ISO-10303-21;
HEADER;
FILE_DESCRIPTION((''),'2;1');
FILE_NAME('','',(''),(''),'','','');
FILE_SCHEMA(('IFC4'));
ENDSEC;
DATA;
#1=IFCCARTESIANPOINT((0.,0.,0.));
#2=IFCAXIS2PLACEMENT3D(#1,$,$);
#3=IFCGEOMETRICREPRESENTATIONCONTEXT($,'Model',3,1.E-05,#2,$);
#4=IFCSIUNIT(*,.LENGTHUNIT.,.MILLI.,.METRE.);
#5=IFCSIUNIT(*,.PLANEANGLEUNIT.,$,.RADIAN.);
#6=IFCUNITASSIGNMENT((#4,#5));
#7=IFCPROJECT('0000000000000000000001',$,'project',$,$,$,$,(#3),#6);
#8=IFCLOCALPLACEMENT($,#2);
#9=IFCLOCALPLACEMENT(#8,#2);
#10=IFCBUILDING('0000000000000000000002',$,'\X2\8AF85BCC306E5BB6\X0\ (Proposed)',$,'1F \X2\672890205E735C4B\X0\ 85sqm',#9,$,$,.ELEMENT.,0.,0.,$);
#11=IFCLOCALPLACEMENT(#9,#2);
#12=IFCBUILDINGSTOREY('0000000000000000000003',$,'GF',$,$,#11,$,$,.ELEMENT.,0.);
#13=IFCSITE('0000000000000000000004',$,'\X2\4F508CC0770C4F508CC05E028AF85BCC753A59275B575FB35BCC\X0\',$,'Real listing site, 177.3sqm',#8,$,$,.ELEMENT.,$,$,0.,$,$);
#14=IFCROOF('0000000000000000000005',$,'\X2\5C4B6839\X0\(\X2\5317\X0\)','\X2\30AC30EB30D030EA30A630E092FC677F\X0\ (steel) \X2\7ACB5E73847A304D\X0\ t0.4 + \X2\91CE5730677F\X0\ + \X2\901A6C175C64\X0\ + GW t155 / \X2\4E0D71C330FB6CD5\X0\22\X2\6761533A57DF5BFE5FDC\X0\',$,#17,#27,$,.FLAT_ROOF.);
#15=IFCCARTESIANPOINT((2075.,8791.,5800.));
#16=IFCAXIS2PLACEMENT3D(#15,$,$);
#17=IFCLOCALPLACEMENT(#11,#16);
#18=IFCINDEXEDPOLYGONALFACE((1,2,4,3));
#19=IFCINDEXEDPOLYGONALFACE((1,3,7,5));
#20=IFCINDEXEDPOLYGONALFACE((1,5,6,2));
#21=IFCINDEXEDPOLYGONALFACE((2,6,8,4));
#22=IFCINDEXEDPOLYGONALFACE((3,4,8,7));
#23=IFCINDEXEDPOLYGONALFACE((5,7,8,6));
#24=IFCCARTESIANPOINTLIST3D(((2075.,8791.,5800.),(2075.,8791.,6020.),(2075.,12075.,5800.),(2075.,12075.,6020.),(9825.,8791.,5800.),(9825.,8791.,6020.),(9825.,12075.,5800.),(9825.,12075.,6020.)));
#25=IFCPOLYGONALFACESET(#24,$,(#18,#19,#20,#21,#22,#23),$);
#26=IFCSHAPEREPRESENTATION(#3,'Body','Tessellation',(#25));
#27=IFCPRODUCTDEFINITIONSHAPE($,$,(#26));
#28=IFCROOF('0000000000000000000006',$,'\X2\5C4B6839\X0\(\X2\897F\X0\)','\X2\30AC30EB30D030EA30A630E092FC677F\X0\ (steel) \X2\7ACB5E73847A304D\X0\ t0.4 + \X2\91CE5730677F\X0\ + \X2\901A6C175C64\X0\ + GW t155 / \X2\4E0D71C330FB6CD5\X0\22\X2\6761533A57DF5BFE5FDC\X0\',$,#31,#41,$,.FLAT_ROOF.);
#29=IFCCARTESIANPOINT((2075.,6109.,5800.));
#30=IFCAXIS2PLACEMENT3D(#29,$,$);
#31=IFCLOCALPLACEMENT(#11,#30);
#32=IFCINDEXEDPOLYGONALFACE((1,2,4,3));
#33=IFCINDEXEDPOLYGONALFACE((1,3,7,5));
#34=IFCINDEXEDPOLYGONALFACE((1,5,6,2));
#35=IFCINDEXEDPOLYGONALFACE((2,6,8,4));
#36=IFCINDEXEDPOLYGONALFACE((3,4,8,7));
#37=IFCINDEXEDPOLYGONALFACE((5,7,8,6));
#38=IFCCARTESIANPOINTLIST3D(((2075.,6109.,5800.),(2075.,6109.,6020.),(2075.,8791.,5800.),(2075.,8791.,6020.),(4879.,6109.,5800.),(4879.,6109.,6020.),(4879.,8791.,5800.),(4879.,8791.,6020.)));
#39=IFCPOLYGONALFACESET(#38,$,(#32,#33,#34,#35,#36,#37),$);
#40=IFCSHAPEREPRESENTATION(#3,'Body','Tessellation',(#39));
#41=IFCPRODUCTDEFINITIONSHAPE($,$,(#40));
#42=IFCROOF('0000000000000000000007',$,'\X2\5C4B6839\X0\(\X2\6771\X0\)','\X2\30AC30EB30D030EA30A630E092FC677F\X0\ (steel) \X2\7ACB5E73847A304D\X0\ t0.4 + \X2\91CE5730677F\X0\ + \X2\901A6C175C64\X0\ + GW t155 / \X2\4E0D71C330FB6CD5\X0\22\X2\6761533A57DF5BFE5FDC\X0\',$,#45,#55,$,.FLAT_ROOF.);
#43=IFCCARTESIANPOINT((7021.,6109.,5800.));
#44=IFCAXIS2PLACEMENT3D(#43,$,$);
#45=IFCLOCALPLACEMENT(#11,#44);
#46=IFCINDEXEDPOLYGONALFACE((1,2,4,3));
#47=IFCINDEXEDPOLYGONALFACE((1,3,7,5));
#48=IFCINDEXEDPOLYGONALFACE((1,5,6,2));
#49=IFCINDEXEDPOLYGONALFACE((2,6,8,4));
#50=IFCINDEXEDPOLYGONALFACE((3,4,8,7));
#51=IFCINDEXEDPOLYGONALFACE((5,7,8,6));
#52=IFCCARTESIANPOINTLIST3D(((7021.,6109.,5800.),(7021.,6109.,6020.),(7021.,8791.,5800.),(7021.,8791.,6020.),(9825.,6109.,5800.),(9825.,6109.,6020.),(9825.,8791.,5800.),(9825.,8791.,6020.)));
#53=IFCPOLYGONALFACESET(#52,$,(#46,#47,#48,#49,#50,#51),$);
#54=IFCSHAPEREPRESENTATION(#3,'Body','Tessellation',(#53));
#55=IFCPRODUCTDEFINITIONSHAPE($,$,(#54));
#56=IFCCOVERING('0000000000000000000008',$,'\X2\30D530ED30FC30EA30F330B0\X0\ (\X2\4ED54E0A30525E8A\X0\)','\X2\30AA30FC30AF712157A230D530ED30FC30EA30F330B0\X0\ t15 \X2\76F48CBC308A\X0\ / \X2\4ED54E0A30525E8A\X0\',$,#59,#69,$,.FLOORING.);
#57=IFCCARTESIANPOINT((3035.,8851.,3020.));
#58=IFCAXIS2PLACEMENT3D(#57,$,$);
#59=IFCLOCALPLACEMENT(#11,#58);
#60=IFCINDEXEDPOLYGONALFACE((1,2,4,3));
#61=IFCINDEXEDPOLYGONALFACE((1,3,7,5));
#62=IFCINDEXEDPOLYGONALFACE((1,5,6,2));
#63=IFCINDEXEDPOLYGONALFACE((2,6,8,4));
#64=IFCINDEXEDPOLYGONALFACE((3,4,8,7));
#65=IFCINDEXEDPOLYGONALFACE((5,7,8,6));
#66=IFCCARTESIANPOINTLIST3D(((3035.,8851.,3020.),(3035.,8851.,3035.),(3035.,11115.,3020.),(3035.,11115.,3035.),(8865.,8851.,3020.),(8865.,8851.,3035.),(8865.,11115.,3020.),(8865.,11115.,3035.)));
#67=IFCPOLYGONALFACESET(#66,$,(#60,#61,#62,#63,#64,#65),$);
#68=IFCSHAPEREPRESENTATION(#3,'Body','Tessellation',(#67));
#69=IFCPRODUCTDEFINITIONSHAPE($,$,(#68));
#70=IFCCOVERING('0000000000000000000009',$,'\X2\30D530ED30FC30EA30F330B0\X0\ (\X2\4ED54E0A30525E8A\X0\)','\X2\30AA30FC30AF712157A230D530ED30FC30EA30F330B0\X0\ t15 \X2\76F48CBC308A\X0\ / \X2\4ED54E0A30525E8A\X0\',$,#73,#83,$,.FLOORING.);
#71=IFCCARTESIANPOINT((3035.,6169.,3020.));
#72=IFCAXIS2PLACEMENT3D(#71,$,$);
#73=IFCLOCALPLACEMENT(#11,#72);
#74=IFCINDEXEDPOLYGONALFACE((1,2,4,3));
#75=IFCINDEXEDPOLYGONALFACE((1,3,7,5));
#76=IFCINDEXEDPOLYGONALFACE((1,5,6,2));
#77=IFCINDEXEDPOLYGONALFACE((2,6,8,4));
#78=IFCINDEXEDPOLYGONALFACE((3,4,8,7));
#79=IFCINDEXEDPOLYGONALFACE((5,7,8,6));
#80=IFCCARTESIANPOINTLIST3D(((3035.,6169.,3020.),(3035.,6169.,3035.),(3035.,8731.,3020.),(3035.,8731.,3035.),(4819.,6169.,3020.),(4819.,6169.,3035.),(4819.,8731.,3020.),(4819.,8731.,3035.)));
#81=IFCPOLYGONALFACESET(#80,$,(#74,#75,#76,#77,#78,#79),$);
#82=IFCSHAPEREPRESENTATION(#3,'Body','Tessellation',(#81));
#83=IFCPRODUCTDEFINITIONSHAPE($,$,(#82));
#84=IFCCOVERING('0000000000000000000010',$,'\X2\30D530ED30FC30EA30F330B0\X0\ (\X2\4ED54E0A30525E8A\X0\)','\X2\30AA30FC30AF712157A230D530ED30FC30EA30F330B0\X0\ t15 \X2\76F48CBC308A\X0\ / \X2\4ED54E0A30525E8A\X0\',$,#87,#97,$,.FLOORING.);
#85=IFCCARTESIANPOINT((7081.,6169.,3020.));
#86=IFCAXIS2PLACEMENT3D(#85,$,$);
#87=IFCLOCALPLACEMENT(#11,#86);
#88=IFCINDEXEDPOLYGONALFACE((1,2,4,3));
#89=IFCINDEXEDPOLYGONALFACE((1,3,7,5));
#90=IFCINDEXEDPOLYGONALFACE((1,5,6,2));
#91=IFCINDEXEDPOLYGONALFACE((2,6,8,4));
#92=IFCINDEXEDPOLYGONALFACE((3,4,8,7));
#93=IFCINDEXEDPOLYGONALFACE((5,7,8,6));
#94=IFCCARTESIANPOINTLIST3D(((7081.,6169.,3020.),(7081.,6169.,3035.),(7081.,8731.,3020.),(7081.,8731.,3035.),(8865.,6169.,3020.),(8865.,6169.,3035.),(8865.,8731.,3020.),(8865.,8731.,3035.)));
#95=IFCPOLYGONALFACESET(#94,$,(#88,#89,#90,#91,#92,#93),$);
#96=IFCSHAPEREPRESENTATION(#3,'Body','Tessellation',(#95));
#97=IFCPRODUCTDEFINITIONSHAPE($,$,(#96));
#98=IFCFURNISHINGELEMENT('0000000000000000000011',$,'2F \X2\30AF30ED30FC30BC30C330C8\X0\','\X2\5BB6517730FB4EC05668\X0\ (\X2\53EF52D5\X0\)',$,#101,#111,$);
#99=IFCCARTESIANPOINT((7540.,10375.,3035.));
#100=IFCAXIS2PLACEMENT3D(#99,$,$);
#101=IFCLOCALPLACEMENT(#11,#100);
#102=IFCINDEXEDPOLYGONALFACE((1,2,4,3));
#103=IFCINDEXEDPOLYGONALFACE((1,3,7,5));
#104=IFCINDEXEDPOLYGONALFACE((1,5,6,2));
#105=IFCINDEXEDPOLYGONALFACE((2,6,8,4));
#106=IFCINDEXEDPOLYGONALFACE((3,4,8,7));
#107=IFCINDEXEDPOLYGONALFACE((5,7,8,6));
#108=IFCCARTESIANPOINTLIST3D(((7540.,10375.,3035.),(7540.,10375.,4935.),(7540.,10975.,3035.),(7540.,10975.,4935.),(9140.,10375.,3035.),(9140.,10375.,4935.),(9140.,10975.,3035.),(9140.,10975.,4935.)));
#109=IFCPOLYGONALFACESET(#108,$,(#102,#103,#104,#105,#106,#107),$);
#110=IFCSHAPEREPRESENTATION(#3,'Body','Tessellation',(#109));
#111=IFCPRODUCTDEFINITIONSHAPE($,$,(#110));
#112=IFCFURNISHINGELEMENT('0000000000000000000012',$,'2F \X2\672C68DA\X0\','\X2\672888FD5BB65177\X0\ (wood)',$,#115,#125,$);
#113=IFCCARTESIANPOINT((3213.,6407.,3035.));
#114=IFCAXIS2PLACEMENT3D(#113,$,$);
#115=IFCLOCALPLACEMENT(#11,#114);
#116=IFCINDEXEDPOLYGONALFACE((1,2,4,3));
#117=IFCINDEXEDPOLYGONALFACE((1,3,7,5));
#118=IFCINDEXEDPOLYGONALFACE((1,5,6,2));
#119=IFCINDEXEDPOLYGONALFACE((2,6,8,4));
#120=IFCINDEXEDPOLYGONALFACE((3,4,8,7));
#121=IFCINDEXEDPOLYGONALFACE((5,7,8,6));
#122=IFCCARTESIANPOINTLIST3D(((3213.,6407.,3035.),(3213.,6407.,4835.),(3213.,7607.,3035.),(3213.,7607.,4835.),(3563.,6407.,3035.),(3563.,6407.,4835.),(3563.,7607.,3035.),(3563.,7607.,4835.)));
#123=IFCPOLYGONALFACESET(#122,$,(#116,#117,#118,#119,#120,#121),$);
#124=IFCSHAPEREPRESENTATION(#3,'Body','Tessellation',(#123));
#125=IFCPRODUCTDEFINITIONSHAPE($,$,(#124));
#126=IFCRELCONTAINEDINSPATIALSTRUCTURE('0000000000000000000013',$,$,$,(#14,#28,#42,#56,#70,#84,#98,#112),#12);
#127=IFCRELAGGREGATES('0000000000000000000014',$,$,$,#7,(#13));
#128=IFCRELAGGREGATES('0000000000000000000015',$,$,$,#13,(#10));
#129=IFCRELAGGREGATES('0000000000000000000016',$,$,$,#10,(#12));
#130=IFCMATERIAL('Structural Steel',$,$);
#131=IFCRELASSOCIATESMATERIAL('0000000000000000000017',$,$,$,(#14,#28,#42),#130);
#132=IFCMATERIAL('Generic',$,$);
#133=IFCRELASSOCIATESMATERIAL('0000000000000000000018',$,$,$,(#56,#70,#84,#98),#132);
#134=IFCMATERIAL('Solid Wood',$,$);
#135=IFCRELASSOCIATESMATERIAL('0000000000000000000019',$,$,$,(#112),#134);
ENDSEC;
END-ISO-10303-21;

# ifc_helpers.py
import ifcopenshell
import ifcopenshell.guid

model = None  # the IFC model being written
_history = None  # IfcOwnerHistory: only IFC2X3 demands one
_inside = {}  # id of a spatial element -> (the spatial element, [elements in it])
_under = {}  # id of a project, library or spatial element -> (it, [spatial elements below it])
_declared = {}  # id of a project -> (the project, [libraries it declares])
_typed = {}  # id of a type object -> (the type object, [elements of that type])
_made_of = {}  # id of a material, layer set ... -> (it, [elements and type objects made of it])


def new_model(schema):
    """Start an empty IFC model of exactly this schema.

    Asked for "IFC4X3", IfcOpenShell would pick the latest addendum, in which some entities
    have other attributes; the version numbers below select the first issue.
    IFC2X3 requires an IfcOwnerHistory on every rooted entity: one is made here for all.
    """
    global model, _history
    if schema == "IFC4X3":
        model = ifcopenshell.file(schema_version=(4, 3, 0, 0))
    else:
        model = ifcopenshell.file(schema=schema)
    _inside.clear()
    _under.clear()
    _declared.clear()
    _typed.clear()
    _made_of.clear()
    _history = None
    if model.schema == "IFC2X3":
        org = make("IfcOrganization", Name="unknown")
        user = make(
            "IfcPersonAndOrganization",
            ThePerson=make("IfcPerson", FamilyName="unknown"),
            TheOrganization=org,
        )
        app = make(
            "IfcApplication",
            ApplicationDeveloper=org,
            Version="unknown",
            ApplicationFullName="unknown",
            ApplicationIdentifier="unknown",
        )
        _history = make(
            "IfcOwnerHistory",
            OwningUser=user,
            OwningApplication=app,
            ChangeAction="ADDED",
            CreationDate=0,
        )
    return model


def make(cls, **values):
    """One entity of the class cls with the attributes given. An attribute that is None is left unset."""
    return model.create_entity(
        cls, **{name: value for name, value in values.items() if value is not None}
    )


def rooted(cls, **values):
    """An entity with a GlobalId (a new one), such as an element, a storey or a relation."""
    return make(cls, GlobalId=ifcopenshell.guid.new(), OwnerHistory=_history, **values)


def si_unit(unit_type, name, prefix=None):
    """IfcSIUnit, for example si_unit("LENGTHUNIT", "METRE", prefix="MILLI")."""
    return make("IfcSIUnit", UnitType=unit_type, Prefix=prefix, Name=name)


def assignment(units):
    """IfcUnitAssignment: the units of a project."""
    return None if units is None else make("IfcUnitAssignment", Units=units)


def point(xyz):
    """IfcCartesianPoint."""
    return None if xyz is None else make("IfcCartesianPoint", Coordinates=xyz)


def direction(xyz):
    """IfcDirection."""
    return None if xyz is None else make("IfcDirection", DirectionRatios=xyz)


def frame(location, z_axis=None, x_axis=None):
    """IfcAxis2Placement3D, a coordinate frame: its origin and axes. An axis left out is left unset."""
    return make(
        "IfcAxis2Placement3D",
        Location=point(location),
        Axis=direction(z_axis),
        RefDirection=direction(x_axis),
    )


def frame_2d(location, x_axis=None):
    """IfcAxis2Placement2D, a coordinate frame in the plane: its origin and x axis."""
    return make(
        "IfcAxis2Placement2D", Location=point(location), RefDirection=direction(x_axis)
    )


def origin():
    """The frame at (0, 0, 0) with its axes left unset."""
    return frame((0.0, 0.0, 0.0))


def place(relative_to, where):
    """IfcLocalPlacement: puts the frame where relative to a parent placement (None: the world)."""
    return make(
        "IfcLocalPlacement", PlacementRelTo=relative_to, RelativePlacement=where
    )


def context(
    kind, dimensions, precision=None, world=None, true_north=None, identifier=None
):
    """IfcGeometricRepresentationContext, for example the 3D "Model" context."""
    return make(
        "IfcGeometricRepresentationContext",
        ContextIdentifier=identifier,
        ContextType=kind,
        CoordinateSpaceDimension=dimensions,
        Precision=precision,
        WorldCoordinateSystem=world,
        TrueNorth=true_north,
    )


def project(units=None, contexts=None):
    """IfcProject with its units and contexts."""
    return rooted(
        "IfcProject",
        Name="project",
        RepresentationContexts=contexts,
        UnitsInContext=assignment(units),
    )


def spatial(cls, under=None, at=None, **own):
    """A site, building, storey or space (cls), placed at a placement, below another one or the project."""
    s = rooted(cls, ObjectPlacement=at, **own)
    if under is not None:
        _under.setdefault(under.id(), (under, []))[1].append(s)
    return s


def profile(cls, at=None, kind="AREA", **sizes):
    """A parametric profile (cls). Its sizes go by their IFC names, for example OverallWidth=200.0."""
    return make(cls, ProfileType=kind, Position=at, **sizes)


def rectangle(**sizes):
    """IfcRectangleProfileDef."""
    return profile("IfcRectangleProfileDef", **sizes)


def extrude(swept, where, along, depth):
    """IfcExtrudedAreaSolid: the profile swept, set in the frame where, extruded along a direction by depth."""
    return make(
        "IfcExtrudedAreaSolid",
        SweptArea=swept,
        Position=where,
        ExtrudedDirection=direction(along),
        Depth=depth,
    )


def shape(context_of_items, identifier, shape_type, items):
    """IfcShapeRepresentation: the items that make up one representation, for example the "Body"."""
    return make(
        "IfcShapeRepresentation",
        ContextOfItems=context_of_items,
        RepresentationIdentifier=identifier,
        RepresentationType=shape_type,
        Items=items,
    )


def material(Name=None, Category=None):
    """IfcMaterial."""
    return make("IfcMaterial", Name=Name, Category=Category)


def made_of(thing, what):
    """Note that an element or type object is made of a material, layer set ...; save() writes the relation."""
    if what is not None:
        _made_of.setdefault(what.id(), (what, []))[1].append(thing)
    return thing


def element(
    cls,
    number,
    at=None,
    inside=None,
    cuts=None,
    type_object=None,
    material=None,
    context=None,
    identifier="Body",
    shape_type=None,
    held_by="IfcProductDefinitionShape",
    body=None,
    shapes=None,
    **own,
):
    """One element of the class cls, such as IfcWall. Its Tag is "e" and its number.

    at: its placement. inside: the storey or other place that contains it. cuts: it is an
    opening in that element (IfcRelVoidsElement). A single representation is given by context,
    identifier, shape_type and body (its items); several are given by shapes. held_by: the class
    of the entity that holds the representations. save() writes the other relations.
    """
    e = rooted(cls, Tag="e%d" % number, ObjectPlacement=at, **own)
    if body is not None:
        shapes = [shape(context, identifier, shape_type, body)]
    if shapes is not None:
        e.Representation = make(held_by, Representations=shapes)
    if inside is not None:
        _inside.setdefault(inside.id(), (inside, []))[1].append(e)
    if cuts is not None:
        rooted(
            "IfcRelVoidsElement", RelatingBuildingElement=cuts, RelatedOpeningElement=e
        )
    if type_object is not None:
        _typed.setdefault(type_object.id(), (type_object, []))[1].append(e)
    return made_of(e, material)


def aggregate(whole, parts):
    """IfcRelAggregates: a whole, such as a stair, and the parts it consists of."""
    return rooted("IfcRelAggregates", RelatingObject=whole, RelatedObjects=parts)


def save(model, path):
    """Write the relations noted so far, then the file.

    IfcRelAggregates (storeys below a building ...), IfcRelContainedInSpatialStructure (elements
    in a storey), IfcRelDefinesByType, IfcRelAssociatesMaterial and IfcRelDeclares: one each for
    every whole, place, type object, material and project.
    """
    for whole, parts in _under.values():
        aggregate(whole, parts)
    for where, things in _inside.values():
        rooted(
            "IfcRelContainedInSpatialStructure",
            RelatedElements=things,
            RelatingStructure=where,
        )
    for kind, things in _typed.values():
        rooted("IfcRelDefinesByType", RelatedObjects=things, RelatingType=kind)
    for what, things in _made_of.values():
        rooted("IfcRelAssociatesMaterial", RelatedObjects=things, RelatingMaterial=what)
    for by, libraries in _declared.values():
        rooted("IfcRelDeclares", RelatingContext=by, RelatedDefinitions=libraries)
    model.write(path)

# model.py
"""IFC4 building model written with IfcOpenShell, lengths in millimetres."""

from ifc_helpers import new_model, si_unit, frame, frame_2d, origin, place, context, project, spatial, rectangle, extrude, material, element, save


model = new_model("IFC4")

# Units and contexts
model_context = context("Model", 3, precision=1e-05, world=origin())
ifc_project = project(units=[si_unit("LENGTHUNIT", "METRE", prefix="MILLI"), si_unit("PLANEANGLEUNIT", "RADIAN")], contexts=[model_context])

# Site, building, storey
site_placement = place(None, origin())
site = spatial("IfcSite", under=ifc_project, at=site_placement, Name="佐賀県佐賀市諸富町大字徳富", ObjectType="Real listing site, 177.3sqm", CompositionType="ELEMENT", RefElevation=0.0)
building_placement = place(site_placement, origin())
building = spatial("IfcBuilding", under=site, at=building_placement, Name="諸富の家 (Proposed)", ObjectType="1F 木造平屋 85sqm", CompositionType="ELEMENT", ElevationOfRefHeight=0.0, ElevationOfTerrain=0.0)
storey_placement = place(building_placement, origin())
storey = spatial("IfcBuildingStorey", under=building, at=storey_placement, Name="GF", CompositionType="ELEMENT", Elevation=0.0)

# Shared definitions
ifc_material_1 = material(Name="Solid Wood")

# Shared definitions
ifc_material_2 = material(Name="Generic")

# Roofs
ifc_material_3 = material(Name="Structural Steel")
for number, where, name in (
    (1, (2075.0, 8791.0, 5800.0), "屋根(北)"),
):
    element("IfcRoof", number, at=place(storey_placement, frame(where)), inside=storey, material=ifc_material_3, Name=name, Description="ガルバリウム鋼板 (steel) 立平葺き t0.4 + 野地板 + 通気層 + GW t155 / 不燃・法22条区域対応", PredefinedType="FLAT_ROOF", context=model_context, shape_type="SweptSolid", body=[
        extrude(rectangle(XDim=7750.0, YDim=3284.0, at=frame_2d((3875.0, 1642.0))), frame((2075.0, 8791.0, 5800.0)), (0.0, 0.0, 1.0), 220.0),
    ])
roof_1_placement = place(storey_placement, frame((2075.0, 6109.0, 5800.0)))
element("IfcRoof", 2, at=roof_1_placement, inside=storey, material=ifc_material_3, Name="屋根(西)", Description="ガルバリウム鋼板 (steel) 立平葺き t0.4 + 野地板 + 通気層 + GW t155 / 不燃・法22条区域対応", PredefinedType="FLAT_ROOF", context=model_context, shape_type="SweptSolid", body=[
    extrude(rectangle(XDim=2804.0, YDim=2682.0, at=frame_2d((1402.0, 1341.0))), frame((2075.0, 6109.0, 5800.0)), (0.0, 0.0, 1.0), 220.0),
])
roof_2_placement = place(storey_placement, frame((7021.0, 6109.0, 5800.0)))
element("IfcRoof", 3, at=roof_2_placement, inside=storey, material=ifc_material_3, Name="屋根(東)", Description="ガルバリウム鋼板 (steel) 立平葺き t0.4 + 野地板 + 通気層 + GW t155 / 不燃・法22条区域対応", PredefinedType="FLAT_ROOF", context=model_context, shape_type="SweptSolid", body=[
    extrude(rectangle(XDim=2804.0, YDim=2682.0, at=frame_2d((1402.0, 1341.0))), frame((7021.0, 6109.0, 5800.0)), (0.0, 0.0, 1.0), 220.0),
])

# Coverings
covering_1_placement = place(storey_placement, frame((3035.0, 8851.0, 3020.0)))
element("IfcCovering", 4, at=covering_1_placement, inside=storey, material=ifc_material_2, Name="フローリング (仕上げ床)", Description="オーク無垢フローリング t15 直貼り / 仕上げ床", PredefinedType="FLOORING", context=model_context, shape_type="SweptSolid", body=[
    extrude(rectangle(XDim=5830.0, YDim=2264.0, at=frame_2d((2915.0, 1132.0))), frame((3035.0, 8851.0, 3020.0)), (0.0, 0.0, 1.0), 15.0),
])
covering_2_placement = place(storey_placement, frame((3035.0, 6169.0, 3020.0)))
element("IfcCovering", 5, at=covering_2_placement, inside=storey, material=ifc_material_2, Name="フローリング (仕上げ床)", Description="オーク無垢フローリング t15 直貼り / 仕上げ床", PredefinedType="FLOORING", context=model_context, shape_type="SweptSolid", body=[
    extrude(rectangle(XDim=1784.0, YDim=2562.0, at=frame_2d((892.0, 1281.0))), frame((3035.0, 6169.0, 3020.0)), (0.0, 0.0, 1.0), 15.0),
])
covering_3_placement = place(storey_placement, frame((7081.0, 6169.0, 3020.0)))
element("IfcCovering", 6, at=covering_3_placement, inside=storey, material=ifc_material_2, Name="フローリング (仕上げ床)", Description="オーク無垢フローリング t15 直貼り / 仕上げ床", PredefinedType="FLOORING", context=model_context, shape_type="SweptSolid", body=[
    extrude(rectangle(XDim=1784.0, YDim=2562.0, at=frame_2d((892.0, 1281.0))), frame((7081.0, 6169.0, 3020.0)), (0.0, 0.0, 1.0), 15.0),
])

# Furnishing elements
furnishing_1_placement = place(storey_placement, frame((7540.0, 10375.0, 3035.0)))
element("IfcFurnishingElement", 7, at=furnishing_1_placement, inside=storey, material=ifc_material_2, Name="2F クローゼット", Description="家具・什器 (可動)", context=model_context, shape_type="SweptSolid", body=[
    extrude(rectangle(XDim=1600.0, YDim=600.0, at=frame_2d((800.0, 300.0))), frame((7540.0, 10375.0, 3035.0)), (0.0, 0.0, 1.0), 1900.0),
])
furnishing_2_placement = place(storey_placement, frame((3213.0, 6407.0, 3035.0)))
element("IfcFurnishingElement", 8, at=furnishing_2_placement, inside=storey, material=ifc_material_1, Name="2F 本棚", Description="木製家具 (wood)", context=model_context, shape_type="SweptSolid", body=[
    extrude(rectangle(XDim=350.0, YDim=1200.0, at=frame_2d((175.0, 600.0))), frame((3213.0, 6407.0, 3035.0)), (0.0, 0.0, 1.0), 1800.0),
])

save(model, "model.ifc")
